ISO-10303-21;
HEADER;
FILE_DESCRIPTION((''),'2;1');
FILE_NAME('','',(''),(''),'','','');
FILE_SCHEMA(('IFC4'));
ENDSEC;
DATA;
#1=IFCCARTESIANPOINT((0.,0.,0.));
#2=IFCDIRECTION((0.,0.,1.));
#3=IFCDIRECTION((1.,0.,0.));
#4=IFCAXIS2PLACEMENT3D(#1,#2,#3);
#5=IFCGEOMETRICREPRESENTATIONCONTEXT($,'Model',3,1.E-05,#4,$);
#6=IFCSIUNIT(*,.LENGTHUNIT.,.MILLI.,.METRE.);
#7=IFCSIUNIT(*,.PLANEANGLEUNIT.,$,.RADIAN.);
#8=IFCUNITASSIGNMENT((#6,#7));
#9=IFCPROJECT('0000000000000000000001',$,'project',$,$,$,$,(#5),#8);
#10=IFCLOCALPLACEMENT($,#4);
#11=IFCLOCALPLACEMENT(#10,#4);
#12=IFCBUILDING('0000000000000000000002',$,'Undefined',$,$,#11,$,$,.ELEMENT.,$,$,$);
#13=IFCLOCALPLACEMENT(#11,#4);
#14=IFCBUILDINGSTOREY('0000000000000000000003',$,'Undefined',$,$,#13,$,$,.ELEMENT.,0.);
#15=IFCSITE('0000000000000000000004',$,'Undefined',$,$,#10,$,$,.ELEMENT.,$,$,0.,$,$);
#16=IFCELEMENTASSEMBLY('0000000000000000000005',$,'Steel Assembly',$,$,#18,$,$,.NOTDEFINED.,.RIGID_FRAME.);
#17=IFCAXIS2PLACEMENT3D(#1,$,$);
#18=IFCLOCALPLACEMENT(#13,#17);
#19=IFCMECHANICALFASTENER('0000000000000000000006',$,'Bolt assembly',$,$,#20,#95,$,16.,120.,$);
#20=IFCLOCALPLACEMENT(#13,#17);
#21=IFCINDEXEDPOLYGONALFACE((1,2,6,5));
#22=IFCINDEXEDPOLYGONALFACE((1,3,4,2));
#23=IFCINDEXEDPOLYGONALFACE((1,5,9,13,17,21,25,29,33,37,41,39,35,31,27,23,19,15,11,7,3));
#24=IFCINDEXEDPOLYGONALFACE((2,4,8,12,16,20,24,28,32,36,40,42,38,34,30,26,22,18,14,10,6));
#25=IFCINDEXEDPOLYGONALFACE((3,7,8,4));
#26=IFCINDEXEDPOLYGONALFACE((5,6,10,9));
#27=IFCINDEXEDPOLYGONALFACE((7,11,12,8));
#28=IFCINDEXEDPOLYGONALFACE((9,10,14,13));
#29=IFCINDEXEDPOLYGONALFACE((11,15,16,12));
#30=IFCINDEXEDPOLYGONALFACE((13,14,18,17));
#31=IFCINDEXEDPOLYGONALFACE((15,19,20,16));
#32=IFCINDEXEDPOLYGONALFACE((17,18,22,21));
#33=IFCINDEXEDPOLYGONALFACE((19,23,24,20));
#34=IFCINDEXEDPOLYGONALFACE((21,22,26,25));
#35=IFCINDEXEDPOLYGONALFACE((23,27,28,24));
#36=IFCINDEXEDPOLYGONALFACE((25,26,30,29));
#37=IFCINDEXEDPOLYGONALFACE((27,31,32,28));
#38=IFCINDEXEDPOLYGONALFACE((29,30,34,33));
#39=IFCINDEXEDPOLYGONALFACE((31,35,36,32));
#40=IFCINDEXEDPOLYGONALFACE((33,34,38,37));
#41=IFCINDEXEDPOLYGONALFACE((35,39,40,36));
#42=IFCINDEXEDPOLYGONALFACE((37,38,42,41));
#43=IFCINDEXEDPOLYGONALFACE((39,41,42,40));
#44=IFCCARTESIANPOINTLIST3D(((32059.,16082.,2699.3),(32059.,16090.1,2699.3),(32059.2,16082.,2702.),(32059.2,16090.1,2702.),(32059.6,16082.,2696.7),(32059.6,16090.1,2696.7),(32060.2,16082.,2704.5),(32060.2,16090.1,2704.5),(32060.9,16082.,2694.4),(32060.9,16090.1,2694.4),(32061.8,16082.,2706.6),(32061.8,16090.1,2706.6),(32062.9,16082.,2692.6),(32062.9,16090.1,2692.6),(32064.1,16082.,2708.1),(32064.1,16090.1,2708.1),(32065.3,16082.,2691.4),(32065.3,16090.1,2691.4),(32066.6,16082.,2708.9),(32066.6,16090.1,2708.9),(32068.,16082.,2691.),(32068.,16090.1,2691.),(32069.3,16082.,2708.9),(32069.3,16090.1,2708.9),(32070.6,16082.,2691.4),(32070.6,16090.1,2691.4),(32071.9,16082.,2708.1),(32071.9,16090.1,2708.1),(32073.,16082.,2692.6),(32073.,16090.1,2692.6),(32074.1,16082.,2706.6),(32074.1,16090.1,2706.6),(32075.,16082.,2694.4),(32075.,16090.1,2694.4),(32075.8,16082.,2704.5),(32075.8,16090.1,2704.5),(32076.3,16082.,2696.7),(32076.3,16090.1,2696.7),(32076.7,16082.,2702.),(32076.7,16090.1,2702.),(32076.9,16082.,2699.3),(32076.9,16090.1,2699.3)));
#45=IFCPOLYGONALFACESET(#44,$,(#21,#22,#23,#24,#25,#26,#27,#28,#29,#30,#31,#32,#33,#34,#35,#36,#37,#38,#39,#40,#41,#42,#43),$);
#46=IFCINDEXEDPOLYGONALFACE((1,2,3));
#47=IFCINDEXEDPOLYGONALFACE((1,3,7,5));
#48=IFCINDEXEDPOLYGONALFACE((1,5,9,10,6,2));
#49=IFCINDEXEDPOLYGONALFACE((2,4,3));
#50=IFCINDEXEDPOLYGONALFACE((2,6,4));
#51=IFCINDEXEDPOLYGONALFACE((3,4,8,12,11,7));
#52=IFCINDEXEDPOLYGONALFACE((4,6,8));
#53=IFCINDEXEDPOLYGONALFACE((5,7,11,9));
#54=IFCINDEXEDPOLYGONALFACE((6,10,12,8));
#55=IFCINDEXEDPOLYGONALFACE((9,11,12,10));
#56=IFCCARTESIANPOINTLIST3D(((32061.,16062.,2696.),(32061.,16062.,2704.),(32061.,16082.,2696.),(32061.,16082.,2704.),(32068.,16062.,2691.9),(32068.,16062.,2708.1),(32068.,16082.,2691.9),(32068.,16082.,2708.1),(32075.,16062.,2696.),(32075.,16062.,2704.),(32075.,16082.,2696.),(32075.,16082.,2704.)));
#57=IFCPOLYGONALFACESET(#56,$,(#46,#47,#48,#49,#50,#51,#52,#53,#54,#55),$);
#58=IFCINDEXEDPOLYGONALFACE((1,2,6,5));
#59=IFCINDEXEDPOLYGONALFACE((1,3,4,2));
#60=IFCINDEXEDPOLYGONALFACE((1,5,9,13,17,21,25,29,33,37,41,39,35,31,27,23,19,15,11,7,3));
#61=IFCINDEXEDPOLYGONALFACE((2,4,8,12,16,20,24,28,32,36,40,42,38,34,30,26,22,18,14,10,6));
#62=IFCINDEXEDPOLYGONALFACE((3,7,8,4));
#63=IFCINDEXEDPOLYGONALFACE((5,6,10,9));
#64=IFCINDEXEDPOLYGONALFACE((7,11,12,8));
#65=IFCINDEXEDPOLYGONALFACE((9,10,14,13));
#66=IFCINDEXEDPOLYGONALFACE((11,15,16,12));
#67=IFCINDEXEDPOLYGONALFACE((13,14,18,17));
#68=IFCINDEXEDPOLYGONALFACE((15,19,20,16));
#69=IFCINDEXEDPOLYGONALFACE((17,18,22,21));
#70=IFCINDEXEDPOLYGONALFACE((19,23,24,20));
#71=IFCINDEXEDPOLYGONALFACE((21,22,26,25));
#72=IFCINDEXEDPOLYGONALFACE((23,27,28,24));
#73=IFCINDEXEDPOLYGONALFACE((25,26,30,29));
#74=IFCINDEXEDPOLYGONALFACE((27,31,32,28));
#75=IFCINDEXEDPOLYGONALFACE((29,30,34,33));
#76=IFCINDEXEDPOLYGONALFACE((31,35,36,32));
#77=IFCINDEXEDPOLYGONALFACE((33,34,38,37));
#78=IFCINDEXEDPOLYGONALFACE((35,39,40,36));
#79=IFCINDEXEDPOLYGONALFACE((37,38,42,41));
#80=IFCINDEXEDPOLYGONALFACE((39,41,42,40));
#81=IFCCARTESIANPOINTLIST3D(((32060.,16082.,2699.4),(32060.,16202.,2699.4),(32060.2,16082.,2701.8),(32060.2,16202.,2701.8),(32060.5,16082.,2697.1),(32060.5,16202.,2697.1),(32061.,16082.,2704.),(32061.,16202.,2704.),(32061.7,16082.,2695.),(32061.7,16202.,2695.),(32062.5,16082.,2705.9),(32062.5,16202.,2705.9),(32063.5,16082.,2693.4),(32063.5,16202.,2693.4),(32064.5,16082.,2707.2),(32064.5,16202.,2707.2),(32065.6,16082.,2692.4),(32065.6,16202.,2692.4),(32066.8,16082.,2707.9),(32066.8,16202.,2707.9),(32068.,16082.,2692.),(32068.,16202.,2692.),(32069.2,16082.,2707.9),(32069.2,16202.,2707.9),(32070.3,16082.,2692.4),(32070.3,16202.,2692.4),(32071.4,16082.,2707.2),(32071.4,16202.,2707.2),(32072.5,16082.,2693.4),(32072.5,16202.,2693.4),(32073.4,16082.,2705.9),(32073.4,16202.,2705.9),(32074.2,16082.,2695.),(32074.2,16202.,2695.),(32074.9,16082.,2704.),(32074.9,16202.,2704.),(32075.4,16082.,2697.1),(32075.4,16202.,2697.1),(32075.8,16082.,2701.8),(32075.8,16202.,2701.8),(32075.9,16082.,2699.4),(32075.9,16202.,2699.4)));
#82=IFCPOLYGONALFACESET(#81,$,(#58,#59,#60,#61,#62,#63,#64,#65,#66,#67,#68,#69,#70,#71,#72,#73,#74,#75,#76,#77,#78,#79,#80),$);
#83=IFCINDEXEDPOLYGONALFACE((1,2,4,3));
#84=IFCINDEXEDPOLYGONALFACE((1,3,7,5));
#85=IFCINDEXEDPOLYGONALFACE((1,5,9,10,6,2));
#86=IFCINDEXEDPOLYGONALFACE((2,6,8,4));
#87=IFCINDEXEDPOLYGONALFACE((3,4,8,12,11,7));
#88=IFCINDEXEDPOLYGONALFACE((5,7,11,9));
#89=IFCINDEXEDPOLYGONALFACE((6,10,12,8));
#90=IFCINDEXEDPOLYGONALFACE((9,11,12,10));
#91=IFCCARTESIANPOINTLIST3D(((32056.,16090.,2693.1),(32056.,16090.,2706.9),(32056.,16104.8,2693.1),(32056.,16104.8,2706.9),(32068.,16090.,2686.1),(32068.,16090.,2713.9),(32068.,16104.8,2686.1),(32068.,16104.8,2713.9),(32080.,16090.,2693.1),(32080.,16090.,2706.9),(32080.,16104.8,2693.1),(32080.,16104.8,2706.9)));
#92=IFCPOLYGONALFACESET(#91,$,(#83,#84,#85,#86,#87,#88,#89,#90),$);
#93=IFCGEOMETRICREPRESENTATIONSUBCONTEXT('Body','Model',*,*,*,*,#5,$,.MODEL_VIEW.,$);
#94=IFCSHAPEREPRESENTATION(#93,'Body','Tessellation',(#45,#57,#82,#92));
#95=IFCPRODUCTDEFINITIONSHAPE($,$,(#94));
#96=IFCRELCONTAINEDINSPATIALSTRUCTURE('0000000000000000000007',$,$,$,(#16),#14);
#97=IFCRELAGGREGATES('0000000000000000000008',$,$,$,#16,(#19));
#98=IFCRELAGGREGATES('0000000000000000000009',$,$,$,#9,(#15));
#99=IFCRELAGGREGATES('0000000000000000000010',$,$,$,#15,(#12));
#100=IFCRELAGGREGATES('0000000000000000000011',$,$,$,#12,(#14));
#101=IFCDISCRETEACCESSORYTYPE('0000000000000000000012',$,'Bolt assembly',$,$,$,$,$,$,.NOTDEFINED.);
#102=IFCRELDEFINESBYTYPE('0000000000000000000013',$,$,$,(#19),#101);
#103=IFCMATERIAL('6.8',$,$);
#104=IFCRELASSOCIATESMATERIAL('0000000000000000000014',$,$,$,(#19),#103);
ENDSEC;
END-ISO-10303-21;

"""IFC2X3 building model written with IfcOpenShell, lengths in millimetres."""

from ifc_helpers import new_model, si_unit, frame, origin_with_axes, origin_2d_with_axis, place, context, subcontext, project, spatial, polyline, circle, outline, extrude, source, transform, mapped, material, type_object, element, aggregate, save


model = new_model("IFC2X3")

# Units and contexts
model_context = context("Model", 3, precision=1e-05, world=origin_with_axes())
body_context = subcontext(model_context, "Body", "Model", "MODEL_VIEW")
ifc_project = project(units=[si_unit("LENGTHUNIT", "METRE", prefix="MILLI"), si_unit("PLANEANGLEUNIT", "RADIAN")], contexts=[model_context])

# Site, building, storey
site_placement = place(None, origin_with_axes())
site = spatial("IfcSite", under=ifc_project, at=site_placement, Name="Undefined", CompositionType="ELEMENT", RefElevation=0.0)
building_placement = place(site_placement, origin_with_axes())
building = spatial("IfcBuilding", under=site, at=building_placement, Name="Undefined", CompositionType="ELEMENT")
storey_placement = place(building_placement, origin_with_axes())
storey = spatial("IfcBuildingStorey", under=building, at=storey_placement, Name="Undefined", CompositionType="ELEMENT", Elevation=0.0)

# Shared definitions
ifc_material_1 = material(Name="6.8")
discrete_accessory_type_1 = type_object("IfcDiscreteAccessoryType", Name="Bolt assembly")
shared_shape_1 = source(origin_with_axes(), body_context, "Body", "SweptSolid", [
    extrude(circle(Radius=9.0, at=origin_2d_with_axis()), frame((0.0, -8.0, 0.0), z_axis=(0.0, 1.0, 0.0), x_axis=(1.0, 0.0, 0.0)), (0.0, 0.0, 1.0), 8.1),
    extrude(outline(polyline([(8.1, 0.0), (4.0, 7.0), (-4.0, 7.0), (-8.1, 0.0), (-4.0, -7.0), (4.0, -7.0), (8.1, 0.0)])), frame((0.0, -28.0, 0.0), z_axis=(0.0, 1.0, 0.0), x_axis=(1.0, 0.0, 0.0)), (0.0, 0.0, 1.0), 20.0),
    extrude(circle(Radius=8.0, at=origin_2d_with_axis()), frame((0.0, -8.0, 0.0), z_axis=(0.0, 1.0, 0.0), x_axis=(1.0, 0.0, 0.0)), (0.0, 0.0, 1.0), 120.0),
    extrude(outline(polyline([(13.9, 0.0), (6.9, 12.0), (-6.9, 12.0), (-13.9, 0.0), (-6.9, -12.0), (6.9, -12.0), (13.9, 0.0)])), frame((0.0, 0.0, 0.0), z_axis=(0.0, 1.0, 0.0), x_axis=(1.0, 0.0, 0.0)), (0.0, 0.0, 1.0), 14.8),
])

# Element assembly, mechanical fastener
assembly_1_placement = place(storey_placement, origin_with_axes())
assembly_1 = element("IfcElementAssembly", 1, at=assembly_1_placement, inside=storey, Name="Steel Assembly", AssemblyPlace="NOTDEFINED", PredefinedType="RIGID_FRAME")
mechanical_fastener_1_placement = place(assembly_1_placement, frame((32068.0, 16090.0, 2700.0), z_axis=(1.0, 0.0, 0.0), x_axis=(0.0, 0.0, -1.0)))
mechanical_fastener_1 = element("IfcMechanicalFastener", 2, at=mechanical_fastener_1_placement, type_object=discrete_accessory_type_1, material=ifc_material_1, Name="Bolt assembly", NominalDiameter=16.0, NominalLength=120.0, context=body_context, shape_type="MappedRepresentation", body=[
    mapped(shared_shape_1, transform((0.0, 0.0, 0.0))),
])

aggregate(assembly_1, [mechanical_fastener_1])

save(model, "model.ifc")
